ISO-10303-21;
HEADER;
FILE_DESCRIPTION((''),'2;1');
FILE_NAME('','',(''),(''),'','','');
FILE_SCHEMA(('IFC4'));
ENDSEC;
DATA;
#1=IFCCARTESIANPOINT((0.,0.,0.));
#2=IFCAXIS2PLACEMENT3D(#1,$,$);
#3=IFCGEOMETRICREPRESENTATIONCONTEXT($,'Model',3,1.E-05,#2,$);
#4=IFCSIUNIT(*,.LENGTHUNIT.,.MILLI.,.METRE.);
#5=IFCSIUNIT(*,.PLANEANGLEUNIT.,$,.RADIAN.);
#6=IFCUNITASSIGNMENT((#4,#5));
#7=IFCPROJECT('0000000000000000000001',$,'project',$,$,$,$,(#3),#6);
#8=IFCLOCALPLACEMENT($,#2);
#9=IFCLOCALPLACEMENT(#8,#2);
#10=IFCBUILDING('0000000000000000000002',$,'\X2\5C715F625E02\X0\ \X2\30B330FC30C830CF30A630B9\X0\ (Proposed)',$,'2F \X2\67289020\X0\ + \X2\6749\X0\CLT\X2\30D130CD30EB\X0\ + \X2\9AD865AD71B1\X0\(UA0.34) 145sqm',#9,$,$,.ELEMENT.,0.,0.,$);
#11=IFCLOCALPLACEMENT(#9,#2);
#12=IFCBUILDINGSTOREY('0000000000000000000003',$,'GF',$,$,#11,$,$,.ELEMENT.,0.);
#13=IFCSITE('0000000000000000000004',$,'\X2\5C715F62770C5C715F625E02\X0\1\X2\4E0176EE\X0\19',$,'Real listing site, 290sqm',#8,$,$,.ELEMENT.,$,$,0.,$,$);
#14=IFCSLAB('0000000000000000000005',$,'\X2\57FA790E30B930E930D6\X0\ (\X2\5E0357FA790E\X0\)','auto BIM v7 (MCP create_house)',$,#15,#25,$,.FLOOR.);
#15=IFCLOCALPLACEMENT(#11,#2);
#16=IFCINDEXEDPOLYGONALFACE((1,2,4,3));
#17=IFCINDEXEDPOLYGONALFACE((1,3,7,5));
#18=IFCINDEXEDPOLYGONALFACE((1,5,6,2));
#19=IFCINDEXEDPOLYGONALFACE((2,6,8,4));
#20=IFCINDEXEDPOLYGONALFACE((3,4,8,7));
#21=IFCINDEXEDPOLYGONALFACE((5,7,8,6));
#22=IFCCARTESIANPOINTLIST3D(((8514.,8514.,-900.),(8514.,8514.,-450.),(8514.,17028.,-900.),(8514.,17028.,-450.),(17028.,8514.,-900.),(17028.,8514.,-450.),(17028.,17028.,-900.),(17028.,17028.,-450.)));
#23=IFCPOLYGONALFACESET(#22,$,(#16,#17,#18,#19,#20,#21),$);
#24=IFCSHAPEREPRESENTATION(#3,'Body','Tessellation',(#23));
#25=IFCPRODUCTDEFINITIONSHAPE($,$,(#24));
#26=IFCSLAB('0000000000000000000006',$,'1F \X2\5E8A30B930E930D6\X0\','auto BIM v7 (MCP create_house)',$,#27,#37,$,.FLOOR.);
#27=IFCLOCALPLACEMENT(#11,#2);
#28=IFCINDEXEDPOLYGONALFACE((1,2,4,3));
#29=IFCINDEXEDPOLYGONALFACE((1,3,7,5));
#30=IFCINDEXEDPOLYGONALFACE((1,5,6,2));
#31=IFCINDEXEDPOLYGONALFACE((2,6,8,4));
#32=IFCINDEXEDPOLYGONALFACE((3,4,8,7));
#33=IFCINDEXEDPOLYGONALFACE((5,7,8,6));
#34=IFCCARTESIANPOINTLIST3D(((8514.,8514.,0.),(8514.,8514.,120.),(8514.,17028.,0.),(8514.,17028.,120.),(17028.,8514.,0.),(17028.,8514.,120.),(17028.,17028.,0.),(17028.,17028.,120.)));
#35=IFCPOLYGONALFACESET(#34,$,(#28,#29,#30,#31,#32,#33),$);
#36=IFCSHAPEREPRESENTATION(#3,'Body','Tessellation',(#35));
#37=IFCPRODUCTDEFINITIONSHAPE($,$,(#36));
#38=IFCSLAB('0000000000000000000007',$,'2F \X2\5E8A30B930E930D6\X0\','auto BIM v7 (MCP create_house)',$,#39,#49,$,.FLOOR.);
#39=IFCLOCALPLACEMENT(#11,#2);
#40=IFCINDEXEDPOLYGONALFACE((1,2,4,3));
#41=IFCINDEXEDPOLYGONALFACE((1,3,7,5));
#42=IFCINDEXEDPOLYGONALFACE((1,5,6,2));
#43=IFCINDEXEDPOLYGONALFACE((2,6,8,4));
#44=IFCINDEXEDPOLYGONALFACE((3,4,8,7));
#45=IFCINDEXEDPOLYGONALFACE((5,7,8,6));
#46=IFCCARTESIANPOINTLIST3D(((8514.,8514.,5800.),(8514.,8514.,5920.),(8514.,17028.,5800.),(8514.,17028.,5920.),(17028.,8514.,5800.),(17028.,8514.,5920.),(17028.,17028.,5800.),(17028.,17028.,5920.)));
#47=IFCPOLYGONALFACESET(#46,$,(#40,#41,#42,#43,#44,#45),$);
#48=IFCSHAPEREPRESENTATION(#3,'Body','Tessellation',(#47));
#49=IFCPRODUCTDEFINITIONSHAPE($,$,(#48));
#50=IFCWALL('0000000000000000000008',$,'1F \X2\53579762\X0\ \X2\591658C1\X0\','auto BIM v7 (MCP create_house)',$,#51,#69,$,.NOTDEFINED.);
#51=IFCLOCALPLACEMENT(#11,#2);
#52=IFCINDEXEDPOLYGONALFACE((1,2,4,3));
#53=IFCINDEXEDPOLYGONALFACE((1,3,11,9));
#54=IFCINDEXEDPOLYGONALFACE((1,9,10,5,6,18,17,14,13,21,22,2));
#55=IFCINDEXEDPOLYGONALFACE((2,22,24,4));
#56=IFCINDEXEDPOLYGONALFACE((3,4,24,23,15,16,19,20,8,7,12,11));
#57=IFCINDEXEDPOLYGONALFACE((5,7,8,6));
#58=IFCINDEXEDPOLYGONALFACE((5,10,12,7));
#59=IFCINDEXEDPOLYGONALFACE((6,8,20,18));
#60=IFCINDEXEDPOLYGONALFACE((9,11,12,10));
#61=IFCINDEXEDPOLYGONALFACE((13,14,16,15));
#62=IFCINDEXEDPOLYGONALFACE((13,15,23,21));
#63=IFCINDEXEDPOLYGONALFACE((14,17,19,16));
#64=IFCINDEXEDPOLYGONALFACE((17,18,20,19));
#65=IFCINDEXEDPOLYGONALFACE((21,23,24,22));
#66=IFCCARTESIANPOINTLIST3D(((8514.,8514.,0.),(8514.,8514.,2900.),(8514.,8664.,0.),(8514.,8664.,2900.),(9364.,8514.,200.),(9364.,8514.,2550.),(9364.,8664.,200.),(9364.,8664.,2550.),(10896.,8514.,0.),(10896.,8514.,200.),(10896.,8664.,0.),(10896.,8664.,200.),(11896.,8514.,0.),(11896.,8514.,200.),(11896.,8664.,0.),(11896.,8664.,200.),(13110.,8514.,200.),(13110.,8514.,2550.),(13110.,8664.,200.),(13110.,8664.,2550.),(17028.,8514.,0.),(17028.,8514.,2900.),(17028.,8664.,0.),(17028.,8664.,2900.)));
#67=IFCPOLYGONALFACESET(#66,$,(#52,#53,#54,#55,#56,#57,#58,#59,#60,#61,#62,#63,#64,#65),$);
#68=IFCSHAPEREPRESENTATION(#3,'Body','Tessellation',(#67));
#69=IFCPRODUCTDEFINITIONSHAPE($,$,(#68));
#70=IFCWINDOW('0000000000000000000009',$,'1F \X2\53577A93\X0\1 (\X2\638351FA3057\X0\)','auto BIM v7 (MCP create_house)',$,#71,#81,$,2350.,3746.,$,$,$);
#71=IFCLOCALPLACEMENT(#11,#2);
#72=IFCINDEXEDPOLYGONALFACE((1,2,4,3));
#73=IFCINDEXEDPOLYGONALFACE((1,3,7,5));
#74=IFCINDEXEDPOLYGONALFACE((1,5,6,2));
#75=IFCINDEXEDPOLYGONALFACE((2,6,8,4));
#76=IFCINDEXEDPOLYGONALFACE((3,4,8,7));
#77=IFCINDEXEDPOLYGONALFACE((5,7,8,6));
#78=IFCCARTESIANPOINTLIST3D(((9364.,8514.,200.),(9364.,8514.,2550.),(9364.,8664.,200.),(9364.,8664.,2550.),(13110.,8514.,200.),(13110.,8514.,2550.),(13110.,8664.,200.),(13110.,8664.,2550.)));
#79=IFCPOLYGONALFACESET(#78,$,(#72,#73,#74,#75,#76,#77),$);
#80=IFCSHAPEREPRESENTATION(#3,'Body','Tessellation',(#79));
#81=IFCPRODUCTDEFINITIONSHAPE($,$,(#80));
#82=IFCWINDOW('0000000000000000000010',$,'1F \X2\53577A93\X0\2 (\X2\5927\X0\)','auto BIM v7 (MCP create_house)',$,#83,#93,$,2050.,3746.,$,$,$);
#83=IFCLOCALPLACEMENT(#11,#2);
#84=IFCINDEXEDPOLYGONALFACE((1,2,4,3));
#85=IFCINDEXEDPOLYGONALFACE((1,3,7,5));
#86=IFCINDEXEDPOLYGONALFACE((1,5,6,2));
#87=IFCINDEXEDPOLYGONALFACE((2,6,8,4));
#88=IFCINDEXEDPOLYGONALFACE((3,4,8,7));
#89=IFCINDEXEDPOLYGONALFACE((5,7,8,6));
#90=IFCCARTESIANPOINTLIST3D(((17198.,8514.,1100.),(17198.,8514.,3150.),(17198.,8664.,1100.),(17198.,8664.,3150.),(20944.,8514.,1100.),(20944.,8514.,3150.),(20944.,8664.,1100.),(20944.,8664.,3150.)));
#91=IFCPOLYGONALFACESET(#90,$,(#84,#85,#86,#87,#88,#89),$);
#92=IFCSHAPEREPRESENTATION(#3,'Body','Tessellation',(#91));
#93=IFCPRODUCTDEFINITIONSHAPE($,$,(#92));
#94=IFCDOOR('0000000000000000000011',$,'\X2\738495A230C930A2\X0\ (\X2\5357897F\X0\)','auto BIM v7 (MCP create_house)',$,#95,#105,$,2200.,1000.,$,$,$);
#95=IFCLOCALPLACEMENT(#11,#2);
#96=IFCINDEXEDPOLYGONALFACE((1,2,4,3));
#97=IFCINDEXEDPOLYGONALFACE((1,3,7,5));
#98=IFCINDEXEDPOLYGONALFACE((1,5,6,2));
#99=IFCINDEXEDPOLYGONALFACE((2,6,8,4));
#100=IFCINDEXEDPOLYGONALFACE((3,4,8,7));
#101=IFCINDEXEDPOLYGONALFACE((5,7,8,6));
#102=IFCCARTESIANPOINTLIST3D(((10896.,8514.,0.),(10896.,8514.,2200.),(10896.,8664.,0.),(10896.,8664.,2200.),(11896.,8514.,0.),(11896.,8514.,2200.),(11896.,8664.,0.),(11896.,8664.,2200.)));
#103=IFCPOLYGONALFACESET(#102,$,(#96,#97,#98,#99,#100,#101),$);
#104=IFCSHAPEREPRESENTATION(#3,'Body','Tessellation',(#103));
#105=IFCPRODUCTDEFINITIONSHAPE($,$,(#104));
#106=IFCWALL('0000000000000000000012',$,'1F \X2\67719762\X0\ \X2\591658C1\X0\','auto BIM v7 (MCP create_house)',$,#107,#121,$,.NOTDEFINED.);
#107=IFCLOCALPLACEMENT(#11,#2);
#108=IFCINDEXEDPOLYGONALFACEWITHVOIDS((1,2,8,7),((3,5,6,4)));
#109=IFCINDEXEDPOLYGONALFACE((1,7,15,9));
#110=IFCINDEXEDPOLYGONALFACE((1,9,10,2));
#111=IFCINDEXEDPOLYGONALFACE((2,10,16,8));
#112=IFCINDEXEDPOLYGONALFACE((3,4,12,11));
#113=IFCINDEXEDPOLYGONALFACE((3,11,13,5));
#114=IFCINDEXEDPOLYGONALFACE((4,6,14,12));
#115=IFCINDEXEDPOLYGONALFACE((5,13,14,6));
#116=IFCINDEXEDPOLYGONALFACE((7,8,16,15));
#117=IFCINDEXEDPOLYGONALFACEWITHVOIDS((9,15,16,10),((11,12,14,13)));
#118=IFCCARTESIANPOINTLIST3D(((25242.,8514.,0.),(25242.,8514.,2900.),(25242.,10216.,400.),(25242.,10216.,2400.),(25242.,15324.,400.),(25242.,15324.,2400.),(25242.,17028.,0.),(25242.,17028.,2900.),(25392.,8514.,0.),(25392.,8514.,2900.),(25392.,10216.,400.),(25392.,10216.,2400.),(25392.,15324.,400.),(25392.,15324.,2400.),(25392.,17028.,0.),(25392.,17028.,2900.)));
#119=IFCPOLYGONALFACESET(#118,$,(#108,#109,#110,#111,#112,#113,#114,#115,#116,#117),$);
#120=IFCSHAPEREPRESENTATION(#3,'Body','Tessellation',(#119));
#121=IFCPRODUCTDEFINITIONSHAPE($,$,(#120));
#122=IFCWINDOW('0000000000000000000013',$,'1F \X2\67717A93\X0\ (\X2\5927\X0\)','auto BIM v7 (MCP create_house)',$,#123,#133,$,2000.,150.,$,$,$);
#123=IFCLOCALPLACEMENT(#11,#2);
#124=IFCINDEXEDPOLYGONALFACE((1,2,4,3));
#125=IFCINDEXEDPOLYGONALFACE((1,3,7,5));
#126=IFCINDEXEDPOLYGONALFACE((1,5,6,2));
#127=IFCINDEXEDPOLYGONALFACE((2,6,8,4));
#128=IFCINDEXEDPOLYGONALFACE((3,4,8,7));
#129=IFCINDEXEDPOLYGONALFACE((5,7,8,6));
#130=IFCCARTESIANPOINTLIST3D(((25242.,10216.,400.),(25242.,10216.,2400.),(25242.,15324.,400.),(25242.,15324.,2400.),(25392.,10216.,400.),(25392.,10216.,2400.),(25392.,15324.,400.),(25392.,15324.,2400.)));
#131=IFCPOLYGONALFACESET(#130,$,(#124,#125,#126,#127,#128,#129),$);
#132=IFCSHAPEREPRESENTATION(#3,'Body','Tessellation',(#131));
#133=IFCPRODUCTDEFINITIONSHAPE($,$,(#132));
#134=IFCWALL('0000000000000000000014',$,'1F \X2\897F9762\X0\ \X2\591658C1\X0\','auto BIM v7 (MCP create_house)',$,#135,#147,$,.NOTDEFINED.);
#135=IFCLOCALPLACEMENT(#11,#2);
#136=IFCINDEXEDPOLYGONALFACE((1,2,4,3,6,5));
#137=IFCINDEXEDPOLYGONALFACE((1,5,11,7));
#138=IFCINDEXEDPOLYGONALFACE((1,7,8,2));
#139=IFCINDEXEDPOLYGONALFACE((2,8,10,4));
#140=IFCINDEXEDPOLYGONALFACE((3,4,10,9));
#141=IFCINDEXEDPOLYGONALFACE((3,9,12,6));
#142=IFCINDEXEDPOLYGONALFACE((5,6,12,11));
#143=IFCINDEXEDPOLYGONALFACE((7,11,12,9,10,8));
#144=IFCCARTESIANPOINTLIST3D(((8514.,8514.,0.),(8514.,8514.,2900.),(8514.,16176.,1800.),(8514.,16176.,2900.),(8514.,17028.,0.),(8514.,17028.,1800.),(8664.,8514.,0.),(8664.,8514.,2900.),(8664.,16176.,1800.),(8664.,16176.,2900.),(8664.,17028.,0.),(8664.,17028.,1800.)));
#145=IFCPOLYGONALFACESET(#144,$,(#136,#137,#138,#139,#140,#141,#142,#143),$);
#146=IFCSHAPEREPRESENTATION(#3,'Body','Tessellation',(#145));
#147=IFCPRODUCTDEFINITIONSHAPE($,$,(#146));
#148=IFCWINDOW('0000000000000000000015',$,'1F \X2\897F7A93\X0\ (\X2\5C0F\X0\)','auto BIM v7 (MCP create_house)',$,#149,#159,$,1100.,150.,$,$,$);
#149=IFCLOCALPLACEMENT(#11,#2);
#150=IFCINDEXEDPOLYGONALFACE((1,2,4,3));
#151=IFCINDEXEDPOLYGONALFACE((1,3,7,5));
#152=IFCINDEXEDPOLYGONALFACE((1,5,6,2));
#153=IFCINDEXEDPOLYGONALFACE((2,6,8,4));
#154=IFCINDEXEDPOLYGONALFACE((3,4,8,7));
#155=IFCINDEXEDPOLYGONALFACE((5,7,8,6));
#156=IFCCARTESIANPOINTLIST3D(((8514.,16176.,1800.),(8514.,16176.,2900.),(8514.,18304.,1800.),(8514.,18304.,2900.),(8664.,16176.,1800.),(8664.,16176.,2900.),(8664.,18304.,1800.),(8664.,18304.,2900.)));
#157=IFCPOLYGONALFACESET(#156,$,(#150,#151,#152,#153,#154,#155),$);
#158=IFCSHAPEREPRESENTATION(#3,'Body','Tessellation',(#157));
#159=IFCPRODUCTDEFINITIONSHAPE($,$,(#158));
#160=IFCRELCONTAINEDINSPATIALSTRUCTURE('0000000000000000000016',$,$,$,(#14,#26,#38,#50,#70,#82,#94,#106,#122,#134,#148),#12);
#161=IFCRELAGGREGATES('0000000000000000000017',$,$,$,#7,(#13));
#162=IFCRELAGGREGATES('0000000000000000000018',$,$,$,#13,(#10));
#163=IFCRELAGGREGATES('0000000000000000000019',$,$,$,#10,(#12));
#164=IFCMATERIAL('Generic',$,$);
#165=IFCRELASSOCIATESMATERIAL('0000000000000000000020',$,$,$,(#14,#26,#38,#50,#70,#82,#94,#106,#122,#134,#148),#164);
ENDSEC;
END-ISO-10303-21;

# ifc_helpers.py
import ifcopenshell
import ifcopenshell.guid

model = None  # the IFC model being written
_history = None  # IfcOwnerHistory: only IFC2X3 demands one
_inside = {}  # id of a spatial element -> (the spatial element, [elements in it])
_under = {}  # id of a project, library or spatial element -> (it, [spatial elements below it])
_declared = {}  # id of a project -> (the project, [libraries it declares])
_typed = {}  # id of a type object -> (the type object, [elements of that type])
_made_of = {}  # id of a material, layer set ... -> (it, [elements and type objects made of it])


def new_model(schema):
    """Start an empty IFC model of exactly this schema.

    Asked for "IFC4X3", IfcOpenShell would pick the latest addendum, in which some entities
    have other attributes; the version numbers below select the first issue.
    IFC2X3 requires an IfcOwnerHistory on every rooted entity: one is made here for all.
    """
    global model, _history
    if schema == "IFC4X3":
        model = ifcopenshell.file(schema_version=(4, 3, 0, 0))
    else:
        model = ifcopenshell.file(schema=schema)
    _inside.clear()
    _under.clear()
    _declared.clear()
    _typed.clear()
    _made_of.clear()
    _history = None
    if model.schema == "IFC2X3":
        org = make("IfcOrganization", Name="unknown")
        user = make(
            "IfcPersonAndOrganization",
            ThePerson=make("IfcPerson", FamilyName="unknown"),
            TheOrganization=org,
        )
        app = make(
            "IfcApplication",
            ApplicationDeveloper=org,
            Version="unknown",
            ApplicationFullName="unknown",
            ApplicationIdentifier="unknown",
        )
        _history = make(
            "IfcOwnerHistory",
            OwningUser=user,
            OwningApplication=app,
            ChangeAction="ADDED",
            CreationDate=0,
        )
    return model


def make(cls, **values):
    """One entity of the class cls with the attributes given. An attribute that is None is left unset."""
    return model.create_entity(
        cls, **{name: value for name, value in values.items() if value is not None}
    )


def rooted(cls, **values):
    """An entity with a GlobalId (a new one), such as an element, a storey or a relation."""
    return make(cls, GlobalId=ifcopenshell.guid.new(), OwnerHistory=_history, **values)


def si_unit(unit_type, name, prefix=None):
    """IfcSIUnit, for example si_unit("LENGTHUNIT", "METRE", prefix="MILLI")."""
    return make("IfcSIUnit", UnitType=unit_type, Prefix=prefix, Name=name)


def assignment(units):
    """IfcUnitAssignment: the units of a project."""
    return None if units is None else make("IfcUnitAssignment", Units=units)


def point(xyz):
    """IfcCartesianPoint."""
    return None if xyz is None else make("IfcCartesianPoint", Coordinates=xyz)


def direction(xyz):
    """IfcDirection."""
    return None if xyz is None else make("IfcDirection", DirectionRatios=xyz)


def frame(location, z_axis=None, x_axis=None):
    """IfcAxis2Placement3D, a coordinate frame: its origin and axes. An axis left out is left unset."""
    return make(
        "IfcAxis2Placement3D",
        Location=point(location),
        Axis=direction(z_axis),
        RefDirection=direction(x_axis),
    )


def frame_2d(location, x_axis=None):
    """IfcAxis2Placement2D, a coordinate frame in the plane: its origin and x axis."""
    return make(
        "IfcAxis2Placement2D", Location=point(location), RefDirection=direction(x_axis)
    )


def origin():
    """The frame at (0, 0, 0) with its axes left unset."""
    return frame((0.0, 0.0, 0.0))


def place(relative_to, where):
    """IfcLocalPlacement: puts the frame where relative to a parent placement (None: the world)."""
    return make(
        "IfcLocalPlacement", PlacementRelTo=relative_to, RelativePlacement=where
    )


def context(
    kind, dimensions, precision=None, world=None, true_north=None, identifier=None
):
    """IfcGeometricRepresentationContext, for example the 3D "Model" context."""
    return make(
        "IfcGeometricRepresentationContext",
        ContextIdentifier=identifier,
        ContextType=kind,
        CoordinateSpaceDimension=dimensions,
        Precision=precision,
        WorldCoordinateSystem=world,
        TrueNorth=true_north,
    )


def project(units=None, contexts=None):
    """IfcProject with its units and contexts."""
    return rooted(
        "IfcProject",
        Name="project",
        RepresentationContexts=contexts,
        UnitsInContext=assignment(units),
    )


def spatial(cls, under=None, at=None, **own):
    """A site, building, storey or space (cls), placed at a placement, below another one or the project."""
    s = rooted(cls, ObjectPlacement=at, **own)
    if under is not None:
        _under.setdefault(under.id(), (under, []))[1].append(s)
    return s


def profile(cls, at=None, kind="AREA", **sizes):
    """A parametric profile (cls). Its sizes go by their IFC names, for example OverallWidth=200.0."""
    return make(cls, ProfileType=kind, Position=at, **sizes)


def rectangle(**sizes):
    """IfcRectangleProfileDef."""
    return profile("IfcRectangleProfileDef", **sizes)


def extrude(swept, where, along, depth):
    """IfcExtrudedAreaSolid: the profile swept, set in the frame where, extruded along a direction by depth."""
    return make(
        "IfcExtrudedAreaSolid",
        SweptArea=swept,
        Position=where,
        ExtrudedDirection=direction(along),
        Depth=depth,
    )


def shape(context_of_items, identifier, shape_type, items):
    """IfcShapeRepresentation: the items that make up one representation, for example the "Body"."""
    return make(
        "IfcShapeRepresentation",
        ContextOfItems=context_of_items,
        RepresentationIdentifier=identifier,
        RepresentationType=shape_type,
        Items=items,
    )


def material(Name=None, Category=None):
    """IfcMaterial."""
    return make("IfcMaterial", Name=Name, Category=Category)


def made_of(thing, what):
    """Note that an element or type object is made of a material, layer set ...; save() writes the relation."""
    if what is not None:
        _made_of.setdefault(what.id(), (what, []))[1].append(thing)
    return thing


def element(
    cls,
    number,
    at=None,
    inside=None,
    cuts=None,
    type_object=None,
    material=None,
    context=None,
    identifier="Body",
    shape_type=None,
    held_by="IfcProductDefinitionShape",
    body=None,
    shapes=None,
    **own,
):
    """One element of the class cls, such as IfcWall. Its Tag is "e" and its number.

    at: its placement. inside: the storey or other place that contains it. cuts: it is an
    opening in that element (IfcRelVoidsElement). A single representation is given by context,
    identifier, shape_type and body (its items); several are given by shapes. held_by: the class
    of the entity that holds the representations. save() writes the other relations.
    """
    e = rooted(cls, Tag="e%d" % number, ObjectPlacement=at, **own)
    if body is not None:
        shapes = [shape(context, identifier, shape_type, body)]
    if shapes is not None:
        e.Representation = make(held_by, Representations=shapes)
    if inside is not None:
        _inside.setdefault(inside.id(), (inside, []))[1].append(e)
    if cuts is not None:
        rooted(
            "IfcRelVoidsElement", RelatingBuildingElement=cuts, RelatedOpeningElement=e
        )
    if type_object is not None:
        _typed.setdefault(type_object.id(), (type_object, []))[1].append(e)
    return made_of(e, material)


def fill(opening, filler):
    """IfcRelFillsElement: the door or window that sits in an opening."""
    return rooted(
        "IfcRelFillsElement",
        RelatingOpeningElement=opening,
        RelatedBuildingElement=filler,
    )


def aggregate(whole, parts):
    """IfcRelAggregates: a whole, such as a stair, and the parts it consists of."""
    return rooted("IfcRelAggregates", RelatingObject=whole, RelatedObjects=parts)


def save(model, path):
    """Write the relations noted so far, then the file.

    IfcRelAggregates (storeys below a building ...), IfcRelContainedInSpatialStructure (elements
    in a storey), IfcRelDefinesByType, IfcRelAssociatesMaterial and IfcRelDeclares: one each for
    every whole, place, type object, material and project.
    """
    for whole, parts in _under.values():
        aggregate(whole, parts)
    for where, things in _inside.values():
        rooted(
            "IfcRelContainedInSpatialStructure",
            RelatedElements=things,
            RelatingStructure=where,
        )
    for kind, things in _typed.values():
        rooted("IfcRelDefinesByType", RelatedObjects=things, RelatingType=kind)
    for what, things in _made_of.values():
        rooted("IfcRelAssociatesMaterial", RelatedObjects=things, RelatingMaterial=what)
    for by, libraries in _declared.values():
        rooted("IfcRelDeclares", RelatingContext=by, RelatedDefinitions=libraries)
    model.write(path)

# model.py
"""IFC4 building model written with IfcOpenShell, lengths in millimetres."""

from ifc_helpers import new_model, si_unit, frame, frame_2d, origin, place, context, project, spatial, rectangle, extrude, material, element, fill, save


model = new_model("IFC4")

# Units and contexts
model_context = context("Model", 3, precision=1e-05, world=origin())
ifc_project = project(units=[si_unit("LENGTHUNIT", "METRE", prefix="MILLI"), si_unit("PLANEANGLEUNIT", "RADIAN")], contexts=[model_context])

# Site, building, storey
site_placement = place(None, origin())
site = spatial("IfcSite", under=ifc_project, at=site_placement, Name="山形県山形市1丁目19", ObjectType="Real listing site, 290sqm", CompositionType="ELEMENT", RefElevation=0.0)
building_placement = place(site_placement, origin())
building = spatial("IfcBuilding", under=site, at=building_placement, Name="山形市 コートハウス (Proposed)", ObjectType="2F 木造 + 杉CLTパネル + 高断熱(UA0.34) 145sqm", CompositionType="ELEMENT", ElevationOfRefHeight=0.0, ElevationOfTerrain=0.0)
storey_placement = place(building_placement, origin())
storey = spatial("IfcBuildingStorey", under=building, at=storey_placement, Name="GF", CompositionType="ELEMENT", Elevation=0.0)

# Slabs
ifc_material = material(Name="Generic")
slab_1_placement = place(storey_placement, frame((4257.0, 4257.0, -450.0)))
element("IfcSlab", 1, at=slab_1_placement, inside=storey, material=ifc_material, Name="基礎スラブ (布基礎)", Description="auto BIM v7 (MCP create_house)", PredefinedType="FLOOR", context=model_context, shape_type="SweptSolid", body=[
    extrude(rectangle(XDim=8514.0, YDim=8514.0, at=frame_2d((4257.0, 4257.0))), frame((4257.0, 4257.0, -450.0)), (0.0, 0.0, 1.0), 450.0),
])
slab_2_placement = place(storey_placement, frame((4257.0, 4257.0, 0.0)))
element("IfcSlab", 2, at=slab_2_placement, inside=storey, material=ifc_material, Name="1F 床スラブ", Description="auto BIM v7 (MCP create_house)", PredefinedType="FLOOR", context=model_context, shape_type="SweptSolid", body=[
    extrude(rectangle(XDim=8514.0, YDim=8514.0, at=frame_2d((4257.0, 4257.0))), frame((4257.0, 4257.0, 0.0)), (0.0, 0.0, 1.0), 120.0),
])
slab_3_placement = place(storey_placement, frame((4257.0, 4257.0, 2900.0)))
element("IfcSlab", 3, at=slab_3_placement, inside=storey, material=ifc_material, Name="2F 床スラブ", Description="auto BIM v7 (MCP create_house)", PredefinedType="FLOOR", context=model_context, shape_type="SweptSolid", body=[
    extrude(rectangle(XDim=8514.0, YDim=8514.0, at=frame_2d((4257.0, 4257.0))), frame((4257.0, 4257.0, 2900.0)), (0.0, 0.0, 1.0), 120.0),
])

# Wall, openings, windows, door
wall_1_placement = place(storey_placement, frame((4257.0, 4257.0, 0.0)))
wall_1 = element("IfcWall", 4, at=wall_1_placement, inside=storey, material=ifc_material, Name="1F 南面 外壁", Description="auto BIM v7 (MCP create_house)", PredefinedType="NOTDEFINED", context=model_context, shape_type="SweptSolid", body=[
    extrude(rectangle(XDim=8514.0, YDim=150.0, at=frame_2d((4257.0, 75.0))), frame((4257.0, 4257.0, 0.0)), (0.0, 0.0, 1.0), 2900.0),
])
opening_1_placement = place(storey_placement, frame((4682.0, 4257.0, 100.0)))
opening_1 = element("IfcOpeningElement", 5, at=opening_1_placement, cuts=wall_1, PredefinedType="NOTDEFINED", context=model_context, shape_type="SweptSolid", body=[
    extrude(rectangle(XDim=3746.0, YDim=150.0, at=frame_2d((1873.0, 75.0))), frame((4682.0, 4257.0, 100.0)), (0.0, 0.0, 1.0), 2350.0),
])
opening_2_placement = place(storey_placement, frame((8599.0, 4257.0, 550.0)))
opening_2 = element("IfcOpeningElement", 6, at=opening_2_placement, cuts=wall_1, PredefinedType="NOTDEFINED", context=model_context, shape_type="SweptSolid", body=[
    extrude(rectangle(XDim=3746.0, YDim=150.0, at=frame_2d((1873.0, 75.0))), frame((8599.0, 4257.0, 550.0)), (0.0, 0.0, 1.0), 2050.0),
])
opening_3_placement = place(storey_placement, frame((5448.0, 4257.0, 0.0)))
opening_3 = element("IfcOpeningElement", 7, at=opening_3_placement, cuts=wall_1, PredefinedType="NOTDEFINED", context=model_context, shape_type="SweptSolid", body=[
    extrude(rectangle(XDim=1000.0, YDim=150.0, at=frame_2d((500.0, 75.0))), frame((5448.0, 4257.0, 0.0)), (0.0, 0.0, 1.0), 2200.0),
])
window_1_placement = place(storey_placement, frame((4682.0, 4257.0, 100.0)))
window_1 = element("IfcWindow", 8, at=window_1_placement, inside=storey, material=ifc_material, Name="1F 南窓1 (掃出し)", Description="auto BIM v7 (MCP create_house)", OverallHeight=2350.0, OverallWidth=3746.0, context=model_context, shape_type="SweptSolid", body=[
    extrude(rectangle(XDim=3746.0, YDim=150.0, at=frame_2d((1873.0, 75.0))), frame((4682.0, 4257.0, 100.0)), (0.0, 0.0, 1.0), 2350.0),
])
fill(opening_1, window_1)
window_2_placement = place(storey_placement, frame((8599.0, 4257.0, 550.0)))
window_2 = element("IfcWindow", 9, at=window_2_placement, inside=storey, material=ifc_material, Name="1F 南窓2 (大)", Description="auto BIM v7 (MCP create_house)", OverallHeight=2050.0, OverallWidth=3746.0, context=model_context, shape_type="SweptSolid", body=[
    extrude(rectangle(XDim=3746.0, YDim=150.0, at=frame_2d((1873.0, 75.0))), frame((8599.0, 4257.0, 550.0)), (0.0, 0.0, 1.0), 2050.0),
])
fill(opening_2, window_2)
door_placement = place(storey_placement, frame((5448.0, 4257.0, 0.0)))
door = element("IfcDoor", 10, at=door_placement, inside=storey, material=ifc_material, Name="玄関ドア (南西)", Description="auto BIM v7 (MCP create_house)", OverallHeight=2200.0, OverallWidth=1000.0, context=model_context, shape_type="SweptSolid", body=[
    extrude(rectangle(XDim=1000.0, YDim=150.0, at=frame_2d((500.0, 75.0))), frame((5448.0, 4257.0, 0.0)), (0.0, 0.0, 1.0), 2200.0),
])
fill(opening_3, door)

# Walls, openings, windows
wall_2_placement = place(storey_placement, frame((12621.0, 4257.0, 0.0)))
wall_2 = element("IfcWall", 11, at=wall_2_placement, inside=storey, material=ifc_material, Name="1F 東面 外壁", Description="auto BIM v7 (MCP create_house)", PredefinedType="NOTDEFINED", context=model_context, shape_type="SweptSolid", body=[
    extrude(rectangle(XDim=150.0, YDim=8514.0, at=frame_2d((75.0, 4257.0))), frame((12621.0, 4257.0, 0.0)), (0.0, 0.0, 1.0), 2900.0),
])
opening_4_placement = place(storey_placement, frame((12621.0, 5108.0, 200.0)))
opening_4 = element("IfcOpeningElement", 12, at=opening_4_placement, cuts=wall_2, PredefinedType="NOTDEFINED", context=model_context, shape_type="SweptSolid", body=[
    extrude(rectangle(XDim=150.0, YDim=5108.0, at=frame_2d((75.0, 2554.0))), frame((12621.0, 5108.0, 200.0)), (0.0, 0.0, 1.0), 2000.0),
])
window_3_placement = place(storey_placement, frame((12621.0, 5108.0, 200.0)))
window_3 = element("IfcWindow", 13, at=window_3_placement, inside=storey, material=ifc_material, Name="1F 東窓 (大)", Description="auto BIM v7 (MCP create_house)", OverallHeight=2000.0, OverallWidth=150.0, context=model_context, shape_type="SweptSolid", body=[
    extrude(rectangle(XDim=150.0, YDim=5108.0, at=frame_2d((75.0, 2554.0))), frame((12621.0, 5108.0, 200.0)), (0.0, 0.0, 1.0), 2000.0),
])
fill(opening_4, window_3)
wall_3_placement = place(storey_placement, frame((4257.0, 4257.0, 0.0)))
wall_3 = element("IfcWall", 14, at=wall_3_placement, inside=storey, material=ifc_material, Name="1F 西面 外壁", Description="auto BIM v7 (MCP create_house)", PredefinedType="NOTDEFINED", context=model_context, shape_type="SweptSolid", body=[
    extrude(rectangle(XDim=150.0, YDim=8514.0, at=frame_2d((75.0, 4257.0))), frame((4257.0, 4257.0, 0.0)), (0.0, 0.0, 1.0), 2900.0),
])
opening_5_placement = place(storey_placement, frame((4257.0, 8088.0, 900.0)))
opening_5 = element("IfcOpeningElement", 15, at=opening_5_placement, cuts=wall_3, PredefinedType="NOTDEFINED", context=model_context, shape_type="SweptSolid", body=[
    extrude(rectangle(XDim=150.0, YDim=2128.0, at=frame_2d((75.0, 1064.0))), frame((4257.0, 8088.0, 900.0)), (0.0, 0.0, 1.0), 1100.0),
])
window_4_placement = place(storey_placement, frame((4257.0, 8088.0, 900.0)))
window_4 = element("IfcWindow", 16, at=window_4_placement, inside=storey, material=ifc_material, Name="1F 西窓 (小)", Description="auto BIM v7 (MCP create_house)", OverallHeight=1100.0, OverallWidth=150.0, context=model_context, shape_type="SweptSolid", body=[
    extrude(rectangle(XDim=150.0, YDim=2128.0, at=frame_2d((75.0, 1064.0))), frame((4257.0, 8088.0, 900.0)), (0.0, 0.0, 1.0), 1100.0),
])
fill(opening_5, window_4)

save(model, "model.ifc")
